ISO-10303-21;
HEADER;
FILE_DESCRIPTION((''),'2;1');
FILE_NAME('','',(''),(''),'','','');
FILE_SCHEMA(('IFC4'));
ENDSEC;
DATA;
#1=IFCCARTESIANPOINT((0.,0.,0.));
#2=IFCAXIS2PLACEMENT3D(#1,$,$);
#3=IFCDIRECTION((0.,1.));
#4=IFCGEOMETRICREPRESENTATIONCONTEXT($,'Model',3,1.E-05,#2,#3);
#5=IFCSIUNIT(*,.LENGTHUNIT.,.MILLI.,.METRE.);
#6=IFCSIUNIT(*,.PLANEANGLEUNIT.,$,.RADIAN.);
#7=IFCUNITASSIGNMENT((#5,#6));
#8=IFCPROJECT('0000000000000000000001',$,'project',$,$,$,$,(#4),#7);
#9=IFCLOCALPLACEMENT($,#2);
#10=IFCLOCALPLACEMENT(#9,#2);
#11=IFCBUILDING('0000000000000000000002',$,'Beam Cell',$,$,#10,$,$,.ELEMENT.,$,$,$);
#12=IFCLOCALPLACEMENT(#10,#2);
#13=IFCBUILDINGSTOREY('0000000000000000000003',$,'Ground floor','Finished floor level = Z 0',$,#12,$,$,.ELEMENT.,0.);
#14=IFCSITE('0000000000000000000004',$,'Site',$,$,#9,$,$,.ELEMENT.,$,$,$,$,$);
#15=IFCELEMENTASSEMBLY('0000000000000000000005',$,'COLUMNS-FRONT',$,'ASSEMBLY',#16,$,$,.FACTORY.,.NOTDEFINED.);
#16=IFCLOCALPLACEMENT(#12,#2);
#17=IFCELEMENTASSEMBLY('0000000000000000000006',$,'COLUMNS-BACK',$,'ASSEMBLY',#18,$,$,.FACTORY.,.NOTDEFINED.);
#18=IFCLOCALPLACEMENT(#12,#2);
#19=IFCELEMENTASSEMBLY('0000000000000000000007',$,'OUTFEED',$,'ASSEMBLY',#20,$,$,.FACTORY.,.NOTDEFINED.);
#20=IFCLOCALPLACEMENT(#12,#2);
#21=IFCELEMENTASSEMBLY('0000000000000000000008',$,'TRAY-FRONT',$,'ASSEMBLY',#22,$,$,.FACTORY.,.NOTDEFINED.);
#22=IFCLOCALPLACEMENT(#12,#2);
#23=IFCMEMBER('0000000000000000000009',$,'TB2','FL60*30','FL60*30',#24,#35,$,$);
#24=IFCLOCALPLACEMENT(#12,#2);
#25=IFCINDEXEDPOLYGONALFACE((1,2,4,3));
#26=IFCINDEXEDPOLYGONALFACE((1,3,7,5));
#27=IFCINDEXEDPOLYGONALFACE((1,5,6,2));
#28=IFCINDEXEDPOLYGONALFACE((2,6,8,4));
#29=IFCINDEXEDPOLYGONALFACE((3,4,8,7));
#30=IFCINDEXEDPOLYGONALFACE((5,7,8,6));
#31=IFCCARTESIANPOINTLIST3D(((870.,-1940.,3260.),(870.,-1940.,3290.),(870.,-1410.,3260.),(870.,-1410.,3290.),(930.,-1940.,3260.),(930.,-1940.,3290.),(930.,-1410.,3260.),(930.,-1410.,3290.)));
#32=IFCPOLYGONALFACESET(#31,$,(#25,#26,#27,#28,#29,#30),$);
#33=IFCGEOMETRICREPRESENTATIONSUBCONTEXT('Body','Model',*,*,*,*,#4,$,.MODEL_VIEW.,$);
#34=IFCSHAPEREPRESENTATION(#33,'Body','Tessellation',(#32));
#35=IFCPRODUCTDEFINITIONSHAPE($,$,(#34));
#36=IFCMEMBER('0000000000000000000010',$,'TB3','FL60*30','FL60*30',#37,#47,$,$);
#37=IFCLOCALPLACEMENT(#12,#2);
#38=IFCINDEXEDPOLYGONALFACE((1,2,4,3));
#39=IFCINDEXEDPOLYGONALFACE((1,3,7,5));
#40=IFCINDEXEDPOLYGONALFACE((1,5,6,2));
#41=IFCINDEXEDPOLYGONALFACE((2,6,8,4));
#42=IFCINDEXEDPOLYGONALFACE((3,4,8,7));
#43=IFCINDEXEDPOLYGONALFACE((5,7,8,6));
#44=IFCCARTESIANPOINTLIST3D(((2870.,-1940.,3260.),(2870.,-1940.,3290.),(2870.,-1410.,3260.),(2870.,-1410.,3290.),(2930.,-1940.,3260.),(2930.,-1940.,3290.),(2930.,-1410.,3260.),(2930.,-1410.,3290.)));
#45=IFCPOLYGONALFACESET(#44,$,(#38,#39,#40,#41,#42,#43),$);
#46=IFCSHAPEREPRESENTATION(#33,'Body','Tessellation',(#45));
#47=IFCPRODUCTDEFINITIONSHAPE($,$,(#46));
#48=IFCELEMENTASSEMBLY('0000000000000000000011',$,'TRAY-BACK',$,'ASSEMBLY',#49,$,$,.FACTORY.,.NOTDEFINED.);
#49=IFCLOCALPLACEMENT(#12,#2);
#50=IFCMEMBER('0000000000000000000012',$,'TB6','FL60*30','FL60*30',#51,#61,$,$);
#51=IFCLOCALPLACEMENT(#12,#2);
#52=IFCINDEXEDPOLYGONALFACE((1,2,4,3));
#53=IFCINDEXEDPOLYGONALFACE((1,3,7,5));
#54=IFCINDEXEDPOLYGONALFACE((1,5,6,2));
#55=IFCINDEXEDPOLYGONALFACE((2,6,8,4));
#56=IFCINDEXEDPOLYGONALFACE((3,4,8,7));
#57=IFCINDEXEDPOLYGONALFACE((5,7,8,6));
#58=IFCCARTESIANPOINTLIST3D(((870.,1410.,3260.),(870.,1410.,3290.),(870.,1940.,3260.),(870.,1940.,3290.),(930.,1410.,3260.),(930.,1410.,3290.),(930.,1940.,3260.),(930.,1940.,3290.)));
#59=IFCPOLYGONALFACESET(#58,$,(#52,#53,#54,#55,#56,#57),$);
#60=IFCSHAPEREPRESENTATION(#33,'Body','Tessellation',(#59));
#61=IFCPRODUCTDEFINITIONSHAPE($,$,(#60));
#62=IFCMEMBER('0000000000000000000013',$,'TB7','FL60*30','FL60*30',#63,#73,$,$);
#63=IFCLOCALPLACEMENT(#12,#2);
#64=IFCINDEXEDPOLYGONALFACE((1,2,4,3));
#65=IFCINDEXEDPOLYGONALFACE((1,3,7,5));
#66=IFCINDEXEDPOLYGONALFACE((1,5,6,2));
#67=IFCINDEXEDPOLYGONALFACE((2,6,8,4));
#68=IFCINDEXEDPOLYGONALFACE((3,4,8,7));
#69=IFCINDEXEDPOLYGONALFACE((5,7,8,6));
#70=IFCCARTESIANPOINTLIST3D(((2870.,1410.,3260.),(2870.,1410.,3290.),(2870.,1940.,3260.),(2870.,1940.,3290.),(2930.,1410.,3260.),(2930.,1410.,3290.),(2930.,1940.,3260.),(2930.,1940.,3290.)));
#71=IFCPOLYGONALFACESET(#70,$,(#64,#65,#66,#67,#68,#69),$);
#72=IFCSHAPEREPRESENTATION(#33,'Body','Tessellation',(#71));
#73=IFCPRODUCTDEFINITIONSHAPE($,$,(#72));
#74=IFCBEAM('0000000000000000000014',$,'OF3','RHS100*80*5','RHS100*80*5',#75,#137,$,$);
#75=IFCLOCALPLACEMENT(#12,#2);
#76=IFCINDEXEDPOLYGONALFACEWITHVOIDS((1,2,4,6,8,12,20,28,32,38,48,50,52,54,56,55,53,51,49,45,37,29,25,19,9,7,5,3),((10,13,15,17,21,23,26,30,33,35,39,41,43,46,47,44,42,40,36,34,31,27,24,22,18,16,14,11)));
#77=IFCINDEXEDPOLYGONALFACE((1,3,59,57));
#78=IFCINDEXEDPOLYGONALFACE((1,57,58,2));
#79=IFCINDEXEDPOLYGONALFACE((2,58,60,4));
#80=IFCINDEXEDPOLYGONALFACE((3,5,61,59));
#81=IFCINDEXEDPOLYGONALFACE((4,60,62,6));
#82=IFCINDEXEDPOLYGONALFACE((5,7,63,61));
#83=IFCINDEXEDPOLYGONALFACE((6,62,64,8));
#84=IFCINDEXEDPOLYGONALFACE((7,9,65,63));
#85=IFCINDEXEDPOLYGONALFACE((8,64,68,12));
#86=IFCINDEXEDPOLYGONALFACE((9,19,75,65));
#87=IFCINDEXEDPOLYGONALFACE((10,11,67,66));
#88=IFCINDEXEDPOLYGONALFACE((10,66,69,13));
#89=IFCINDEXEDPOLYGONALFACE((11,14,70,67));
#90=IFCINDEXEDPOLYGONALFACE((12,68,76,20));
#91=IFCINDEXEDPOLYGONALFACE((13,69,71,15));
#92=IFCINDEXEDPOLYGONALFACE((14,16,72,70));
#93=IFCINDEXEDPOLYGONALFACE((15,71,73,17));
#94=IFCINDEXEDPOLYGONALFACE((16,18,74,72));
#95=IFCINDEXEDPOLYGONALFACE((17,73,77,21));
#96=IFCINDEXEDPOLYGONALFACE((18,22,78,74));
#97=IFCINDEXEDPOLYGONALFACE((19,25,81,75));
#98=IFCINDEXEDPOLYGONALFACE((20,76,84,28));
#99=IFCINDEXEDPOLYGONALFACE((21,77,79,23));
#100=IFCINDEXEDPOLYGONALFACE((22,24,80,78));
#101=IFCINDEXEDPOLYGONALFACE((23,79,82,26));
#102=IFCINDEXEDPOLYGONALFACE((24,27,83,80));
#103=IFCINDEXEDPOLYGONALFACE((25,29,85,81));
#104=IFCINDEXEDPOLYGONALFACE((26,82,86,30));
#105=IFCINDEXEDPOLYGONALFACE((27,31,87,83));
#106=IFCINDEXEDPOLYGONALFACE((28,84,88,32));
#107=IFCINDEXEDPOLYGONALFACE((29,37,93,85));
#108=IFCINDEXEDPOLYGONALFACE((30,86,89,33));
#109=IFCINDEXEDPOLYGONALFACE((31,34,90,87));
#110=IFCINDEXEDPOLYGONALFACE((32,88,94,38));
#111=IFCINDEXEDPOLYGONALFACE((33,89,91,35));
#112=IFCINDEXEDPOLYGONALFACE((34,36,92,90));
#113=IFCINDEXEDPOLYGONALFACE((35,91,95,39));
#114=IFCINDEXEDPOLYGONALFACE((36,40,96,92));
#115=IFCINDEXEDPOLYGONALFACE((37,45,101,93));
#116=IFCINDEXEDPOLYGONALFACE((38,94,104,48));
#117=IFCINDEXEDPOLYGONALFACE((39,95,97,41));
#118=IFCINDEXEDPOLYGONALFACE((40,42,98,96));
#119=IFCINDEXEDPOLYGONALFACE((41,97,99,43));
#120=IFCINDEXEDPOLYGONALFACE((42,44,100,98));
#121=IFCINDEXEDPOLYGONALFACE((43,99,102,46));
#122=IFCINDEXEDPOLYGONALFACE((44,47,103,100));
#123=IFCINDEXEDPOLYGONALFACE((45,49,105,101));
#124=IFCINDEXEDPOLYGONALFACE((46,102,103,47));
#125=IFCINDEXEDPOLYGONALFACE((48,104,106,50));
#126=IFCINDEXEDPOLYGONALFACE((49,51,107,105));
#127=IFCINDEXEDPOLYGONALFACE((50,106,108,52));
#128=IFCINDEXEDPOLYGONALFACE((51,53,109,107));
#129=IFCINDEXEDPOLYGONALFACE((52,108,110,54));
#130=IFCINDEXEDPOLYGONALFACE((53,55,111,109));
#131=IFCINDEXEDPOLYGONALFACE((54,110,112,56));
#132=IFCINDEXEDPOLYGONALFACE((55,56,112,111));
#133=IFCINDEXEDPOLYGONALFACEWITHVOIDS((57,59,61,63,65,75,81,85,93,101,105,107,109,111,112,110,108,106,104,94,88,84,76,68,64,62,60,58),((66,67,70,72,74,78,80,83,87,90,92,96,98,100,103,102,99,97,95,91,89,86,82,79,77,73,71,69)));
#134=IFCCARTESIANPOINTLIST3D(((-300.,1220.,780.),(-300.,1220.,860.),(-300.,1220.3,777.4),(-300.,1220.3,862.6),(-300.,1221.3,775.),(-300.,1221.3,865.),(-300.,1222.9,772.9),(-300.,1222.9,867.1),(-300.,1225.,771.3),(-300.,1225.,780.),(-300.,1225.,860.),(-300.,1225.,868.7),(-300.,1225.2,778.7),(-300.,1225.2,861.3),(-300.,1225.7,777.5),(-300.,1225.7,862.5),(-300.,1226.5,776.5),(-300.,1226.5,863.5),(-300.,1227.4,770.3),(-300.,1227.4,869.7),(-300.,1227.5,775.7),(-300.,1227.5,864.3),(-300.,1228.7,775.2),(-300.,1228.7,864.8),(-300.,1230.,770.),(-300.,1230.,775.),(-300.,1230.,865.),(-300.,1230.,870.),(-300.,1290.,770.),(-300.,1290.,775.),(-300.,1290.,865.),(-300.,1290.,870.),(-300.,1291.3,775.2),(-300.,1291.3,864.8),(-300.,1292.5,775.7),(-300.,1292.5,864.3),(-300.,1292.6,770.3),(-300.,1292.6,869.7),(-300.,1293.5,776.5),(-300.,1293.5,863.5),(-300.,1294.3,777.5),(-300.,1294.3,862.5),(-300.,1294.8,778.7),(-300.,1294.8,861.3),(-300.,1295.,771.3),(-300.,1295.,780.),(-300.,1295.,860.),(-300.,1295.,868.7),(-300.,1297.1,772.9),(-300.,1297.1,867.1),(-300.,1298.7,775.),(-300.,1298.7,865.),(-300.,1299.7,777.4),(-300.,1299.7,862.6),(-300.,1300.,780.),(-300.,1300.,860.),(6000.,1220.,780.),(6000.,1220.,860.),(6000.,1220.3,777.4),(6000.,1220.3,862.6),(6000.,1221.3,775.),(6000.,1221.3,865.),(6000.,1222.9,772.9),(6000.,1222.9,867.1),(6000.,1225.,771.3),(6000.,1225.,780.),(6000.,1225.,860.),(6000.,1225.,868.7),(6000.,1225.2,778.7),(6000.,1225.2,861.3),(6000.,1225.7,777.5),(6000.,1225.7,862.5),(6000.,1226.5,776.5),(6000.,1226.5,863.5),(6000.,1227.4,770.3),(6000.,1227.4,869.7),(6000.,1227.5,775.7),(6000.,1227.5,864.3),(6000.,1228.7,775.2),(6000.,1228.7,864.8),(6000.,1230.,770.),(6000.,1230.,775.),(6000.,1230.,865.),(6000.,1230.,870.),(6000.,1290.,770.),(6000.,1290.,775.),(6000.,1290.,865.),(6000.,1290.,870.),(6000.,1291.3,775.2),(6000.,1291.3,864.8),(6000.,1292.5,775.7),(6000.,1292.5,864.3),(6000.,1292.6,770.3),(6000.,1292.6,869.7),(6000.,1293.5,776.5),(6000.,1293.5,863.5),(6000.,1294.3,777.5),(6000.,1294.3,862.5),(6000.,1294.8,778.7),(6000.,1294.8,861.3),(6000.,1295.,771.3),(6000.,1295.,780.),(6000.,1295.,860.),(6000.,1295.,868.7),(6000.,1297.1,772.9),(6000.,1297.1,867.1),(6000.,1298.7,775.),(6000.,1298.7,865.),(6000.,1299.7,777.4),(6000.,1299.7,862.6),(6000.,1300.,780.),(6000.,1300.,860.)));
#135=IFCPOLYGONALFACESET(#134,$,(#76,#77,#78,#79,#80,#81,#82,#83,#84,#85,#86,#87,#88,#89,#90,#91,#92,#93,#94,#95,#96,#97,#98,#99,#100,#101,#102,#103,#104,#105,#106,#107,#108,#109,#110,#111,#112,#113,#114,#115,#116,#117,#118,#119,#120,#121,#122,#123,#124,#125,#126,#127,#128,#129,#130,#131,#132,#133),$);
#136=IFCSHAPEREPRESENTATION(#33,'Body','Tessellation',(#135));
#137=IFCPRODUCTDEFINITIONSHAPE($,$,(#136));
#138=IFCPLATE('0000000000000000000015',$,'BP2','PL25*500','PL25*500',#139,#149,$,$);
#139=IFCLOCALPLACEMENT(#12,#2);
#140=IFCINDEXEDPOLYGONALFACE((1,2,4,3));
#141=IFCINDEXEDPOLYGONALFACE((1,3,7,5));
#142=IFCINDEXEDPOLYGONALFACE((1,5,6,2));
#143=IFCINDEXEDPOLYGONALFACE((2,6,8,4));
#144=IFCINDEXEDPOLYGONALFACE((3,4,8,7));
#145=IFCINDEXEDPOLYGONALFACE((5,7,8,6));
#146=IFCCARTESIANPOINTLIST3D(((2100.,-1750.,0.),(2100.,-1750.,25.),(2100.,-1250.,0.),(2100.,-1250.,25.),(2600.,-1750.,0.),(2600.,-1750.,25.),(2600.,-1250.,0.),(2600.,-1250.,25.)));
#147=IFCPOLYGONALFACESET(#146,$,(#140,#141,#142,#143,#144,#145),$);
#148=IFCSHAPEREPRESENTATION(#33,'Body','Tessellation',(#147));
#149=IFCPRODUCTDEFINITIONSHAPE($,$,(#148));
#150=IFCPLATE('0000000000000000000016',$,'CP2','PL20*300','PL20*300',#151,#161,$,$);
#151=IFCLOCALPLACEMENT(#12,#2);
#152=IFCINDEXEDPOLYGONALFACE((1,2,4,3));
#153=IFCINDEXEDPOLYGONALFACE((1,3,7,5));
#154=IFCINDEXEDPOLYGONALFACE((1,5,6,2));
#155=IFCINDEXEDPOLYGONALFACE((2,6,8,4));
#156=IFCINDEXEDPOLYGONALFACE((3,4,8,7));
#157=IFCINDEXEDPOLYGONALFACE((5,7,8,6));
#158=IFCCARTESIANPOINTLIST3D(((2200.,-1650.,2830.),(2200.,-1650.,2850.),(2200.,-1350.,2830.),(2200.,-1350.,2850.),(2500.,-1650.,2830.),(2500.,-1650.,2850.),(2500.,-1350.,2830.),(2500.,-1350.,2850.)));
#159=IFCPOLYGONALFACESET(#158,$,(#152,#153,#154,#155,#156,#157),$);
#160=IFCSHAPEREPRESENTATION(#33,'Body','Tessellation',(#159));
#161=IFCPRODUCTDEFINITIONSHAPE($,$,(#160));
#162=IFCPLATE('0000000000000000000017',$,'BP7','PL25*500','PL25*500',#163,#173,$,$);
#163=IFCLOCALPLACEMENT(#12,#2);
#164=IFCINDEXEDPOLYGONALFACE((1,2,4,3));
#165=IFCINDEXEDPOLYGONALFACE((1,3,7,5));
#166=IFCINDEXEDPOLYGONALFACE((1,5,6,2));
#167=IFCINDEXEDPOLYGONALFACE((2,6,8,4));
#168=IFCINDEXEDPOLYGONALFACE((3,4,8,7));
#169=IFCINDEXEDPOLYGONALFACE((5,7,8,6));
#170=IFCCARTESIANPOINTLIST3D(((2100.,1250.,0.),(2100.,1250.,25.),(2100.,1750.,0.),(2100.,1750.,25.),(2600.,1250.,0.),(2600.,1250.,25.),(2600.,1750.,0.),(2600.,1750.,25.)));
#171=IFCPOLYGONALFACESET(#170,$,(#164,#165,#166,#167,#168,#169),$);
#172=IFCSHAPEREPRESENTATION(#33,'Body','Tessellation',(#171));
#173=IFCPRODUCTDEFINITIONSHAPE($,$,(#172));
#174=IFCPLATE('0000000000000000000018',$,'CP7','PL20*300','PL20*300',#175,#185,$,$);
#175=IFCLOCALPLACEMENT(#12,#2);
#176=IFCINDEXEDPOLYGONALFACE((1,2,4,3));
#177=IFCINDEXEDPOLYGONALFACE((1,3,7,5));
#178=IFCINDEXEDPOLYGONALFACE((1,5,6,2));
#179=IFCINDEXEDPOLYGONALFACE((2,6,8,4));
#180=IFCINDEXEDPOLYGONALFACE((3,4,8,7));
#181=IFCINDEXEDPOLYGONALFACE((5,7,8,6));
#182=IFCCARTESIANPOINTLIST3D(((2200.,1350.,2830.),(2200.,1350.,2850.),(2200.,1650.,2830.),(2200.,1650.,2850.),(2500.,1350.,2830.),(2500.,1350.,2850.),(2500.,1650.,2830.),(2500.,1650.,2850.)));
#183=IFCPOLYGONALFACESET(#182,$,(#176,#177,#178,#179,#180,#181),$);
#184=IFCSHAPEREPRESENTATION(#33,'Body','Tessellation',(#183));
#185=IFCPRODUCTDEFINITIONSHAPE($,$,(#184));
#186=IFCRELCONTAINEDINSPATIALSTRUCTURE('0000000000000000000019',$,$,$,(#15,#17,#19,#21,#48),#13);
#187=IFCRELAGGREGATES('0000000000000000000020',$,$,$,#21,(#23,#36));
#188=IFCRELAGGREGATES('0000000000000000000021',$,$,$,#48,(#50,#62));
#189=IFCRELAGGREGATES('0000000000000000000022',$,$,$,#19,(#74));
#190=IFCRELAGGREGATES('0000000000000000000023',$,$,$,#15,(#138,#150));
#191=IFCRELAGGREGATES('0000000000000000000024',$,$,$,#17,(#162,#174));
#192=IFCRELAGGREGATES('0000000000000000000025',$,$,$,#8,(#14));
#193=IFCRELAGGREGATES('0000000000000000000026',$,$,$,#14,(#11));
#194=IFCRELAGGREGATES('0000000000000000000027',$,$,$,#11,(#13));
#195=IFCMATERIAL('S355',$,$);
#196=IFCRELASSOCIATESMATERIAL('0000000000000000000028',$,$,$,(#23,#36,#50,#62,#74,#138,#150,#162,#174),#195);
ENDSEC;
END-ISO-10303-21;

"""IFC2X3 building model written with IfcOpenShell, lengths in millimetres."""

from ifc_helpers import new_model, si_unit, direction, frame, origin, origin_2d, place, context, subcontext, project, spatial, rectangle, hollow_rectangle, extrude, material, element, aggregate, save


model = new_model("IFC2X3")

# Units and contexts
model_context = context("Model", 3, precision=1e-05, world=origin(), true_north=direction((0.0, 1.0)))
body_context = subcontext(model_context, "Body", "Model", "MODEL_VIEW")
ifc_project = project(units=[si_unit("LENGTHUNIT", "METRE", prefix="MILLI"), si_unit("PLANEANGLEUNIT", "RADIAN")], contexts=[model_context])

# Site, building, storey
site_placement = place(None, origin())
site = spatial("IfcSite", under=ifc_project, at=site_placement, Name="Site", CompositionType="ELEMENT")
building_placement = place(site_placement, origin())
building = spatial("IfcBuilding", under=site, at=building_placement, Name="Beam Cell", CompositionType="ELEMENT")
storey_placement = place(building_placement, origin())
storey = spatial("IfcBuildingStorey", under=building, at=storey_placement, Name="Ground floor", Description="Finished floor level = Z 0", CompositionType="ELEMENT", Elevation=0.0)

# Element assemblies
assembly_1_placement = place(storey_placement, origin())
assembly_1 = element("IfcElementAssembly", 1, at=assembly_1_placement, inside=storey, Name="COLUMNS-FRONT", ObjectType="ASSEMBLY", AssemblyPlace="FACTORY", PredefinedType="NOTDEFINED")
ifc_material = material(Name="S355")
assembly_2_placement = place(storey_placement, origin())
assembly_2 = element("IfcElementAssembly", 2, at=assembly_2_placement, inside=storey, Name="COLUMNS-BACK", ObjectType="ASSEMBLY", AssemblyPlace="FACTORY", PredefinedType="NOTDEFINED")

# Element assembly
assembly_3_placement = place(storey_placement, origin())
assembly_3 = element("IfcElementAssembly", 3, at=assembly_3_placement, inside=storey, Name="OUTFEED", ObjectType="ASSEMBLY", AssemblyPlace="FACTORY", PredefinedType="NOTDEFINED")

# Element assemblies, members
assembly_4_placement = place(storey_placement, origin())
assembly_4 = element("IfcElementAssembly", 4, at=assembly_4_placement, inside=storey, Name="TRAY-FRONT", ObjectType="ASSEMBLY", AssemblyPlace="FACTORY", PredefinedType="NOTDEFINED")
member_1_placement = place(storey_placement, frame((900.0, -1940.0, 3275.0), z_axis=(0.0, 1.0, 0.0), x_axis=(1.0, 0.0, 0.0)))
member_1 = element("IfcMember", 5, at=member_1_placement, material=ifc_material, Name="TB2", Description="FL60*30", ObjectType="FL60*30", context=body_context, shape_type="SweptSolid", body=[
    extrude(rectangle(XDim=60.0, YDim=30.0, at=origin_2d()), origin(), (0.0, 0.0, 1.0), 530.0),
])
member_2_placement = place(storey_placement, frame((2900.0, -1940.0, 3275.0), z_axis=(0.0, 1.0, 0.0), x_axis=(1.0, 0.0, 0.0)))
member_2 = element("IfcMember", 6, at=member_2_placement, material=ifc_material, Name="TB3", Description="FL60*30", ObjectType="FL60*30", context=body_context, shape_type="SweptSolid", body=[
    extrude(rectangle(XDim=60.0, YDim=30.0, at=origin_2d()), origin(), (0.0, 0.0, 1.0), 530.0),
])
aggregate(assembly_4, [member_1, member_2])
assembly_5_placement = place(storey_placement, origin())
assembly_5 = element("IfcElementAssembly", 7, at=assembly_5_placement, inside=storey, Name="TRAY-BACK", ObjectType="ASSEMBLY", AssemblyPlace="FACTORY", PredefinedType="NOTDEFINED")
member_3_placement = place(storey_placement, frame((900.0, 1410.0, 3275.0), z_axis=(0.0, 1.0, 0.0), x_axis=(1.0, 0.0, 0.0)))
member_3 = element("IfcMember", 8, at=member_3_placement, material=ifc_material, Name="TB6", Description="FL60*30", ObjectType="FL60*30", context=body_context, shape_type="SweptSolid", body=[
    extrude(rectangle(XDim=60.0, YDim=30.0, at=origin_2d()), origin(), (0.0, 0.0, 1.0), 530.0),
])
member_4_placement = place(storey_placement, frame((2900.0, 1410.0, 3275.0), z_axis=(0.0, 1.0, 0.0), x_axis=(1.0, 0.0, 0.0)))
member_4 = element("IfcMember", 9, at=member_4_placement, material=ifc_material, Name="TB7", Description="FL60*30", ObjectType="FL60*30", context=body_context, shape_type="SweptSolid", body=[
    extrude(rectangle(XDim=60.0, YDim=30.0, at=origin_2d()), origin(), (0.0, 0.0, 1.0), 530.0),
])
aggregate(assembly_5, [member_3, member_4])

# Beam
beam_placement = place(storey_placement, frame((-300.0, 1260.0, 820.0), z_axis=(1.0, 0.0, 0.0), x_axis=(0.0, 1.0, 0.0)))
beam = element("IfcBeam", 10, at=beam_placement, material=ifc_material, Name="OF3", Description="RHS100*80*5", ObjectType="RHS100*80*5", context=body_context, shape_type="SweptSolid", body=[
    extrude(hollow_rectangle(XDim=80.0, YDim=100.0, WallThickness=5.0, InnerFilletRadius=5.0, OuterFilletRadius=10.0, at=origin_2d()), origin(), (0.0, 0.0, 1.0), 6300.0),
])
aggregate(assembly_3, [beam])

# Plates
plate_1_placement = place(storey_placement, frame((2350.0, -1500.0, 0.0), z_axis=(0.0, 0.0, 1.0), x_axis=(1.0, 0.0, 0.0)))
plate_1 = element("IfcPlate", 11, at=plate_1_placement, material=ifc_material, Name="BP2", Description="PL25*500", ObjectType="PL25*500", context=body_context, shape_type="SweptSolid", body=[
    extrude(rectangle(XDim=500.0, YDim=500.0, at=origin_2d()), origin(), (0.0, 0.0, 1.0), 25.0),
])
plate_2_placement = place(storey_placement, frame((2350.0, -1500.0, 2830.0), z_axis=(0.0, 0.0, 1.0), x_axis=(1.0, 0.0, 0.0)))
plate_2 = element("IfcPlate", 12, at=plate_2_placement, material=ifc_material, Name="CP2", Description="PL20*300", ObjectType="PL20*300", context=body_context, shape_type="SweptSolid", body=[
    extrude(rectangle(XDim=300.0, YDim=300.0, at=origin_2d()), origin(), (0.0, 0.0, 1.0), 20.0),
])
aggregate(assembly_1, [plate_1, plate_2])
plate_3_placement = place(storey_placement, frame((2350.0, 1500.0, 0.0), z_axis=(0.0, 0.0, 1.0), x_axis=(1.0, 0.0, 0.0)))
plate_3 = element("IfcPlate", 13, at=plate_3_placement, material=ifc_material, Name="BP7", Description="PL25*500", ObjectType="PL25*500", context=body_context, shape_type="SweptSolid", body=[
    extrude(rectangle(XDim=500.0, YDim=500.0, at=origin_2d()), origin(), (0.0, 0.0, 1.0), 25.0),
])
plate_4_placement = place(storey_placement, frame((2350.0, 1500.0, 2830.0), z_axis=(0.0, 0.0, 1.0), x_axis=(1.0, 0.0, 0.0)))
plate_4 = element("IfcPlate", 14, at=plate_4_placement, material=ifc_material, Name="CP7", Description="PL20*300", ObjectType="PL20*300", context=body_context, shape_type="SweptSolid", body=[
    extrude(rectangle(XDim=300.0, YDim=300.0, at=origin_2d()), origin(), (0.0, 0.0, 1.0), 20.0),
])
aggregate(assembly_2, [plate_3, plate_4])

save(model, "model.ifc")
